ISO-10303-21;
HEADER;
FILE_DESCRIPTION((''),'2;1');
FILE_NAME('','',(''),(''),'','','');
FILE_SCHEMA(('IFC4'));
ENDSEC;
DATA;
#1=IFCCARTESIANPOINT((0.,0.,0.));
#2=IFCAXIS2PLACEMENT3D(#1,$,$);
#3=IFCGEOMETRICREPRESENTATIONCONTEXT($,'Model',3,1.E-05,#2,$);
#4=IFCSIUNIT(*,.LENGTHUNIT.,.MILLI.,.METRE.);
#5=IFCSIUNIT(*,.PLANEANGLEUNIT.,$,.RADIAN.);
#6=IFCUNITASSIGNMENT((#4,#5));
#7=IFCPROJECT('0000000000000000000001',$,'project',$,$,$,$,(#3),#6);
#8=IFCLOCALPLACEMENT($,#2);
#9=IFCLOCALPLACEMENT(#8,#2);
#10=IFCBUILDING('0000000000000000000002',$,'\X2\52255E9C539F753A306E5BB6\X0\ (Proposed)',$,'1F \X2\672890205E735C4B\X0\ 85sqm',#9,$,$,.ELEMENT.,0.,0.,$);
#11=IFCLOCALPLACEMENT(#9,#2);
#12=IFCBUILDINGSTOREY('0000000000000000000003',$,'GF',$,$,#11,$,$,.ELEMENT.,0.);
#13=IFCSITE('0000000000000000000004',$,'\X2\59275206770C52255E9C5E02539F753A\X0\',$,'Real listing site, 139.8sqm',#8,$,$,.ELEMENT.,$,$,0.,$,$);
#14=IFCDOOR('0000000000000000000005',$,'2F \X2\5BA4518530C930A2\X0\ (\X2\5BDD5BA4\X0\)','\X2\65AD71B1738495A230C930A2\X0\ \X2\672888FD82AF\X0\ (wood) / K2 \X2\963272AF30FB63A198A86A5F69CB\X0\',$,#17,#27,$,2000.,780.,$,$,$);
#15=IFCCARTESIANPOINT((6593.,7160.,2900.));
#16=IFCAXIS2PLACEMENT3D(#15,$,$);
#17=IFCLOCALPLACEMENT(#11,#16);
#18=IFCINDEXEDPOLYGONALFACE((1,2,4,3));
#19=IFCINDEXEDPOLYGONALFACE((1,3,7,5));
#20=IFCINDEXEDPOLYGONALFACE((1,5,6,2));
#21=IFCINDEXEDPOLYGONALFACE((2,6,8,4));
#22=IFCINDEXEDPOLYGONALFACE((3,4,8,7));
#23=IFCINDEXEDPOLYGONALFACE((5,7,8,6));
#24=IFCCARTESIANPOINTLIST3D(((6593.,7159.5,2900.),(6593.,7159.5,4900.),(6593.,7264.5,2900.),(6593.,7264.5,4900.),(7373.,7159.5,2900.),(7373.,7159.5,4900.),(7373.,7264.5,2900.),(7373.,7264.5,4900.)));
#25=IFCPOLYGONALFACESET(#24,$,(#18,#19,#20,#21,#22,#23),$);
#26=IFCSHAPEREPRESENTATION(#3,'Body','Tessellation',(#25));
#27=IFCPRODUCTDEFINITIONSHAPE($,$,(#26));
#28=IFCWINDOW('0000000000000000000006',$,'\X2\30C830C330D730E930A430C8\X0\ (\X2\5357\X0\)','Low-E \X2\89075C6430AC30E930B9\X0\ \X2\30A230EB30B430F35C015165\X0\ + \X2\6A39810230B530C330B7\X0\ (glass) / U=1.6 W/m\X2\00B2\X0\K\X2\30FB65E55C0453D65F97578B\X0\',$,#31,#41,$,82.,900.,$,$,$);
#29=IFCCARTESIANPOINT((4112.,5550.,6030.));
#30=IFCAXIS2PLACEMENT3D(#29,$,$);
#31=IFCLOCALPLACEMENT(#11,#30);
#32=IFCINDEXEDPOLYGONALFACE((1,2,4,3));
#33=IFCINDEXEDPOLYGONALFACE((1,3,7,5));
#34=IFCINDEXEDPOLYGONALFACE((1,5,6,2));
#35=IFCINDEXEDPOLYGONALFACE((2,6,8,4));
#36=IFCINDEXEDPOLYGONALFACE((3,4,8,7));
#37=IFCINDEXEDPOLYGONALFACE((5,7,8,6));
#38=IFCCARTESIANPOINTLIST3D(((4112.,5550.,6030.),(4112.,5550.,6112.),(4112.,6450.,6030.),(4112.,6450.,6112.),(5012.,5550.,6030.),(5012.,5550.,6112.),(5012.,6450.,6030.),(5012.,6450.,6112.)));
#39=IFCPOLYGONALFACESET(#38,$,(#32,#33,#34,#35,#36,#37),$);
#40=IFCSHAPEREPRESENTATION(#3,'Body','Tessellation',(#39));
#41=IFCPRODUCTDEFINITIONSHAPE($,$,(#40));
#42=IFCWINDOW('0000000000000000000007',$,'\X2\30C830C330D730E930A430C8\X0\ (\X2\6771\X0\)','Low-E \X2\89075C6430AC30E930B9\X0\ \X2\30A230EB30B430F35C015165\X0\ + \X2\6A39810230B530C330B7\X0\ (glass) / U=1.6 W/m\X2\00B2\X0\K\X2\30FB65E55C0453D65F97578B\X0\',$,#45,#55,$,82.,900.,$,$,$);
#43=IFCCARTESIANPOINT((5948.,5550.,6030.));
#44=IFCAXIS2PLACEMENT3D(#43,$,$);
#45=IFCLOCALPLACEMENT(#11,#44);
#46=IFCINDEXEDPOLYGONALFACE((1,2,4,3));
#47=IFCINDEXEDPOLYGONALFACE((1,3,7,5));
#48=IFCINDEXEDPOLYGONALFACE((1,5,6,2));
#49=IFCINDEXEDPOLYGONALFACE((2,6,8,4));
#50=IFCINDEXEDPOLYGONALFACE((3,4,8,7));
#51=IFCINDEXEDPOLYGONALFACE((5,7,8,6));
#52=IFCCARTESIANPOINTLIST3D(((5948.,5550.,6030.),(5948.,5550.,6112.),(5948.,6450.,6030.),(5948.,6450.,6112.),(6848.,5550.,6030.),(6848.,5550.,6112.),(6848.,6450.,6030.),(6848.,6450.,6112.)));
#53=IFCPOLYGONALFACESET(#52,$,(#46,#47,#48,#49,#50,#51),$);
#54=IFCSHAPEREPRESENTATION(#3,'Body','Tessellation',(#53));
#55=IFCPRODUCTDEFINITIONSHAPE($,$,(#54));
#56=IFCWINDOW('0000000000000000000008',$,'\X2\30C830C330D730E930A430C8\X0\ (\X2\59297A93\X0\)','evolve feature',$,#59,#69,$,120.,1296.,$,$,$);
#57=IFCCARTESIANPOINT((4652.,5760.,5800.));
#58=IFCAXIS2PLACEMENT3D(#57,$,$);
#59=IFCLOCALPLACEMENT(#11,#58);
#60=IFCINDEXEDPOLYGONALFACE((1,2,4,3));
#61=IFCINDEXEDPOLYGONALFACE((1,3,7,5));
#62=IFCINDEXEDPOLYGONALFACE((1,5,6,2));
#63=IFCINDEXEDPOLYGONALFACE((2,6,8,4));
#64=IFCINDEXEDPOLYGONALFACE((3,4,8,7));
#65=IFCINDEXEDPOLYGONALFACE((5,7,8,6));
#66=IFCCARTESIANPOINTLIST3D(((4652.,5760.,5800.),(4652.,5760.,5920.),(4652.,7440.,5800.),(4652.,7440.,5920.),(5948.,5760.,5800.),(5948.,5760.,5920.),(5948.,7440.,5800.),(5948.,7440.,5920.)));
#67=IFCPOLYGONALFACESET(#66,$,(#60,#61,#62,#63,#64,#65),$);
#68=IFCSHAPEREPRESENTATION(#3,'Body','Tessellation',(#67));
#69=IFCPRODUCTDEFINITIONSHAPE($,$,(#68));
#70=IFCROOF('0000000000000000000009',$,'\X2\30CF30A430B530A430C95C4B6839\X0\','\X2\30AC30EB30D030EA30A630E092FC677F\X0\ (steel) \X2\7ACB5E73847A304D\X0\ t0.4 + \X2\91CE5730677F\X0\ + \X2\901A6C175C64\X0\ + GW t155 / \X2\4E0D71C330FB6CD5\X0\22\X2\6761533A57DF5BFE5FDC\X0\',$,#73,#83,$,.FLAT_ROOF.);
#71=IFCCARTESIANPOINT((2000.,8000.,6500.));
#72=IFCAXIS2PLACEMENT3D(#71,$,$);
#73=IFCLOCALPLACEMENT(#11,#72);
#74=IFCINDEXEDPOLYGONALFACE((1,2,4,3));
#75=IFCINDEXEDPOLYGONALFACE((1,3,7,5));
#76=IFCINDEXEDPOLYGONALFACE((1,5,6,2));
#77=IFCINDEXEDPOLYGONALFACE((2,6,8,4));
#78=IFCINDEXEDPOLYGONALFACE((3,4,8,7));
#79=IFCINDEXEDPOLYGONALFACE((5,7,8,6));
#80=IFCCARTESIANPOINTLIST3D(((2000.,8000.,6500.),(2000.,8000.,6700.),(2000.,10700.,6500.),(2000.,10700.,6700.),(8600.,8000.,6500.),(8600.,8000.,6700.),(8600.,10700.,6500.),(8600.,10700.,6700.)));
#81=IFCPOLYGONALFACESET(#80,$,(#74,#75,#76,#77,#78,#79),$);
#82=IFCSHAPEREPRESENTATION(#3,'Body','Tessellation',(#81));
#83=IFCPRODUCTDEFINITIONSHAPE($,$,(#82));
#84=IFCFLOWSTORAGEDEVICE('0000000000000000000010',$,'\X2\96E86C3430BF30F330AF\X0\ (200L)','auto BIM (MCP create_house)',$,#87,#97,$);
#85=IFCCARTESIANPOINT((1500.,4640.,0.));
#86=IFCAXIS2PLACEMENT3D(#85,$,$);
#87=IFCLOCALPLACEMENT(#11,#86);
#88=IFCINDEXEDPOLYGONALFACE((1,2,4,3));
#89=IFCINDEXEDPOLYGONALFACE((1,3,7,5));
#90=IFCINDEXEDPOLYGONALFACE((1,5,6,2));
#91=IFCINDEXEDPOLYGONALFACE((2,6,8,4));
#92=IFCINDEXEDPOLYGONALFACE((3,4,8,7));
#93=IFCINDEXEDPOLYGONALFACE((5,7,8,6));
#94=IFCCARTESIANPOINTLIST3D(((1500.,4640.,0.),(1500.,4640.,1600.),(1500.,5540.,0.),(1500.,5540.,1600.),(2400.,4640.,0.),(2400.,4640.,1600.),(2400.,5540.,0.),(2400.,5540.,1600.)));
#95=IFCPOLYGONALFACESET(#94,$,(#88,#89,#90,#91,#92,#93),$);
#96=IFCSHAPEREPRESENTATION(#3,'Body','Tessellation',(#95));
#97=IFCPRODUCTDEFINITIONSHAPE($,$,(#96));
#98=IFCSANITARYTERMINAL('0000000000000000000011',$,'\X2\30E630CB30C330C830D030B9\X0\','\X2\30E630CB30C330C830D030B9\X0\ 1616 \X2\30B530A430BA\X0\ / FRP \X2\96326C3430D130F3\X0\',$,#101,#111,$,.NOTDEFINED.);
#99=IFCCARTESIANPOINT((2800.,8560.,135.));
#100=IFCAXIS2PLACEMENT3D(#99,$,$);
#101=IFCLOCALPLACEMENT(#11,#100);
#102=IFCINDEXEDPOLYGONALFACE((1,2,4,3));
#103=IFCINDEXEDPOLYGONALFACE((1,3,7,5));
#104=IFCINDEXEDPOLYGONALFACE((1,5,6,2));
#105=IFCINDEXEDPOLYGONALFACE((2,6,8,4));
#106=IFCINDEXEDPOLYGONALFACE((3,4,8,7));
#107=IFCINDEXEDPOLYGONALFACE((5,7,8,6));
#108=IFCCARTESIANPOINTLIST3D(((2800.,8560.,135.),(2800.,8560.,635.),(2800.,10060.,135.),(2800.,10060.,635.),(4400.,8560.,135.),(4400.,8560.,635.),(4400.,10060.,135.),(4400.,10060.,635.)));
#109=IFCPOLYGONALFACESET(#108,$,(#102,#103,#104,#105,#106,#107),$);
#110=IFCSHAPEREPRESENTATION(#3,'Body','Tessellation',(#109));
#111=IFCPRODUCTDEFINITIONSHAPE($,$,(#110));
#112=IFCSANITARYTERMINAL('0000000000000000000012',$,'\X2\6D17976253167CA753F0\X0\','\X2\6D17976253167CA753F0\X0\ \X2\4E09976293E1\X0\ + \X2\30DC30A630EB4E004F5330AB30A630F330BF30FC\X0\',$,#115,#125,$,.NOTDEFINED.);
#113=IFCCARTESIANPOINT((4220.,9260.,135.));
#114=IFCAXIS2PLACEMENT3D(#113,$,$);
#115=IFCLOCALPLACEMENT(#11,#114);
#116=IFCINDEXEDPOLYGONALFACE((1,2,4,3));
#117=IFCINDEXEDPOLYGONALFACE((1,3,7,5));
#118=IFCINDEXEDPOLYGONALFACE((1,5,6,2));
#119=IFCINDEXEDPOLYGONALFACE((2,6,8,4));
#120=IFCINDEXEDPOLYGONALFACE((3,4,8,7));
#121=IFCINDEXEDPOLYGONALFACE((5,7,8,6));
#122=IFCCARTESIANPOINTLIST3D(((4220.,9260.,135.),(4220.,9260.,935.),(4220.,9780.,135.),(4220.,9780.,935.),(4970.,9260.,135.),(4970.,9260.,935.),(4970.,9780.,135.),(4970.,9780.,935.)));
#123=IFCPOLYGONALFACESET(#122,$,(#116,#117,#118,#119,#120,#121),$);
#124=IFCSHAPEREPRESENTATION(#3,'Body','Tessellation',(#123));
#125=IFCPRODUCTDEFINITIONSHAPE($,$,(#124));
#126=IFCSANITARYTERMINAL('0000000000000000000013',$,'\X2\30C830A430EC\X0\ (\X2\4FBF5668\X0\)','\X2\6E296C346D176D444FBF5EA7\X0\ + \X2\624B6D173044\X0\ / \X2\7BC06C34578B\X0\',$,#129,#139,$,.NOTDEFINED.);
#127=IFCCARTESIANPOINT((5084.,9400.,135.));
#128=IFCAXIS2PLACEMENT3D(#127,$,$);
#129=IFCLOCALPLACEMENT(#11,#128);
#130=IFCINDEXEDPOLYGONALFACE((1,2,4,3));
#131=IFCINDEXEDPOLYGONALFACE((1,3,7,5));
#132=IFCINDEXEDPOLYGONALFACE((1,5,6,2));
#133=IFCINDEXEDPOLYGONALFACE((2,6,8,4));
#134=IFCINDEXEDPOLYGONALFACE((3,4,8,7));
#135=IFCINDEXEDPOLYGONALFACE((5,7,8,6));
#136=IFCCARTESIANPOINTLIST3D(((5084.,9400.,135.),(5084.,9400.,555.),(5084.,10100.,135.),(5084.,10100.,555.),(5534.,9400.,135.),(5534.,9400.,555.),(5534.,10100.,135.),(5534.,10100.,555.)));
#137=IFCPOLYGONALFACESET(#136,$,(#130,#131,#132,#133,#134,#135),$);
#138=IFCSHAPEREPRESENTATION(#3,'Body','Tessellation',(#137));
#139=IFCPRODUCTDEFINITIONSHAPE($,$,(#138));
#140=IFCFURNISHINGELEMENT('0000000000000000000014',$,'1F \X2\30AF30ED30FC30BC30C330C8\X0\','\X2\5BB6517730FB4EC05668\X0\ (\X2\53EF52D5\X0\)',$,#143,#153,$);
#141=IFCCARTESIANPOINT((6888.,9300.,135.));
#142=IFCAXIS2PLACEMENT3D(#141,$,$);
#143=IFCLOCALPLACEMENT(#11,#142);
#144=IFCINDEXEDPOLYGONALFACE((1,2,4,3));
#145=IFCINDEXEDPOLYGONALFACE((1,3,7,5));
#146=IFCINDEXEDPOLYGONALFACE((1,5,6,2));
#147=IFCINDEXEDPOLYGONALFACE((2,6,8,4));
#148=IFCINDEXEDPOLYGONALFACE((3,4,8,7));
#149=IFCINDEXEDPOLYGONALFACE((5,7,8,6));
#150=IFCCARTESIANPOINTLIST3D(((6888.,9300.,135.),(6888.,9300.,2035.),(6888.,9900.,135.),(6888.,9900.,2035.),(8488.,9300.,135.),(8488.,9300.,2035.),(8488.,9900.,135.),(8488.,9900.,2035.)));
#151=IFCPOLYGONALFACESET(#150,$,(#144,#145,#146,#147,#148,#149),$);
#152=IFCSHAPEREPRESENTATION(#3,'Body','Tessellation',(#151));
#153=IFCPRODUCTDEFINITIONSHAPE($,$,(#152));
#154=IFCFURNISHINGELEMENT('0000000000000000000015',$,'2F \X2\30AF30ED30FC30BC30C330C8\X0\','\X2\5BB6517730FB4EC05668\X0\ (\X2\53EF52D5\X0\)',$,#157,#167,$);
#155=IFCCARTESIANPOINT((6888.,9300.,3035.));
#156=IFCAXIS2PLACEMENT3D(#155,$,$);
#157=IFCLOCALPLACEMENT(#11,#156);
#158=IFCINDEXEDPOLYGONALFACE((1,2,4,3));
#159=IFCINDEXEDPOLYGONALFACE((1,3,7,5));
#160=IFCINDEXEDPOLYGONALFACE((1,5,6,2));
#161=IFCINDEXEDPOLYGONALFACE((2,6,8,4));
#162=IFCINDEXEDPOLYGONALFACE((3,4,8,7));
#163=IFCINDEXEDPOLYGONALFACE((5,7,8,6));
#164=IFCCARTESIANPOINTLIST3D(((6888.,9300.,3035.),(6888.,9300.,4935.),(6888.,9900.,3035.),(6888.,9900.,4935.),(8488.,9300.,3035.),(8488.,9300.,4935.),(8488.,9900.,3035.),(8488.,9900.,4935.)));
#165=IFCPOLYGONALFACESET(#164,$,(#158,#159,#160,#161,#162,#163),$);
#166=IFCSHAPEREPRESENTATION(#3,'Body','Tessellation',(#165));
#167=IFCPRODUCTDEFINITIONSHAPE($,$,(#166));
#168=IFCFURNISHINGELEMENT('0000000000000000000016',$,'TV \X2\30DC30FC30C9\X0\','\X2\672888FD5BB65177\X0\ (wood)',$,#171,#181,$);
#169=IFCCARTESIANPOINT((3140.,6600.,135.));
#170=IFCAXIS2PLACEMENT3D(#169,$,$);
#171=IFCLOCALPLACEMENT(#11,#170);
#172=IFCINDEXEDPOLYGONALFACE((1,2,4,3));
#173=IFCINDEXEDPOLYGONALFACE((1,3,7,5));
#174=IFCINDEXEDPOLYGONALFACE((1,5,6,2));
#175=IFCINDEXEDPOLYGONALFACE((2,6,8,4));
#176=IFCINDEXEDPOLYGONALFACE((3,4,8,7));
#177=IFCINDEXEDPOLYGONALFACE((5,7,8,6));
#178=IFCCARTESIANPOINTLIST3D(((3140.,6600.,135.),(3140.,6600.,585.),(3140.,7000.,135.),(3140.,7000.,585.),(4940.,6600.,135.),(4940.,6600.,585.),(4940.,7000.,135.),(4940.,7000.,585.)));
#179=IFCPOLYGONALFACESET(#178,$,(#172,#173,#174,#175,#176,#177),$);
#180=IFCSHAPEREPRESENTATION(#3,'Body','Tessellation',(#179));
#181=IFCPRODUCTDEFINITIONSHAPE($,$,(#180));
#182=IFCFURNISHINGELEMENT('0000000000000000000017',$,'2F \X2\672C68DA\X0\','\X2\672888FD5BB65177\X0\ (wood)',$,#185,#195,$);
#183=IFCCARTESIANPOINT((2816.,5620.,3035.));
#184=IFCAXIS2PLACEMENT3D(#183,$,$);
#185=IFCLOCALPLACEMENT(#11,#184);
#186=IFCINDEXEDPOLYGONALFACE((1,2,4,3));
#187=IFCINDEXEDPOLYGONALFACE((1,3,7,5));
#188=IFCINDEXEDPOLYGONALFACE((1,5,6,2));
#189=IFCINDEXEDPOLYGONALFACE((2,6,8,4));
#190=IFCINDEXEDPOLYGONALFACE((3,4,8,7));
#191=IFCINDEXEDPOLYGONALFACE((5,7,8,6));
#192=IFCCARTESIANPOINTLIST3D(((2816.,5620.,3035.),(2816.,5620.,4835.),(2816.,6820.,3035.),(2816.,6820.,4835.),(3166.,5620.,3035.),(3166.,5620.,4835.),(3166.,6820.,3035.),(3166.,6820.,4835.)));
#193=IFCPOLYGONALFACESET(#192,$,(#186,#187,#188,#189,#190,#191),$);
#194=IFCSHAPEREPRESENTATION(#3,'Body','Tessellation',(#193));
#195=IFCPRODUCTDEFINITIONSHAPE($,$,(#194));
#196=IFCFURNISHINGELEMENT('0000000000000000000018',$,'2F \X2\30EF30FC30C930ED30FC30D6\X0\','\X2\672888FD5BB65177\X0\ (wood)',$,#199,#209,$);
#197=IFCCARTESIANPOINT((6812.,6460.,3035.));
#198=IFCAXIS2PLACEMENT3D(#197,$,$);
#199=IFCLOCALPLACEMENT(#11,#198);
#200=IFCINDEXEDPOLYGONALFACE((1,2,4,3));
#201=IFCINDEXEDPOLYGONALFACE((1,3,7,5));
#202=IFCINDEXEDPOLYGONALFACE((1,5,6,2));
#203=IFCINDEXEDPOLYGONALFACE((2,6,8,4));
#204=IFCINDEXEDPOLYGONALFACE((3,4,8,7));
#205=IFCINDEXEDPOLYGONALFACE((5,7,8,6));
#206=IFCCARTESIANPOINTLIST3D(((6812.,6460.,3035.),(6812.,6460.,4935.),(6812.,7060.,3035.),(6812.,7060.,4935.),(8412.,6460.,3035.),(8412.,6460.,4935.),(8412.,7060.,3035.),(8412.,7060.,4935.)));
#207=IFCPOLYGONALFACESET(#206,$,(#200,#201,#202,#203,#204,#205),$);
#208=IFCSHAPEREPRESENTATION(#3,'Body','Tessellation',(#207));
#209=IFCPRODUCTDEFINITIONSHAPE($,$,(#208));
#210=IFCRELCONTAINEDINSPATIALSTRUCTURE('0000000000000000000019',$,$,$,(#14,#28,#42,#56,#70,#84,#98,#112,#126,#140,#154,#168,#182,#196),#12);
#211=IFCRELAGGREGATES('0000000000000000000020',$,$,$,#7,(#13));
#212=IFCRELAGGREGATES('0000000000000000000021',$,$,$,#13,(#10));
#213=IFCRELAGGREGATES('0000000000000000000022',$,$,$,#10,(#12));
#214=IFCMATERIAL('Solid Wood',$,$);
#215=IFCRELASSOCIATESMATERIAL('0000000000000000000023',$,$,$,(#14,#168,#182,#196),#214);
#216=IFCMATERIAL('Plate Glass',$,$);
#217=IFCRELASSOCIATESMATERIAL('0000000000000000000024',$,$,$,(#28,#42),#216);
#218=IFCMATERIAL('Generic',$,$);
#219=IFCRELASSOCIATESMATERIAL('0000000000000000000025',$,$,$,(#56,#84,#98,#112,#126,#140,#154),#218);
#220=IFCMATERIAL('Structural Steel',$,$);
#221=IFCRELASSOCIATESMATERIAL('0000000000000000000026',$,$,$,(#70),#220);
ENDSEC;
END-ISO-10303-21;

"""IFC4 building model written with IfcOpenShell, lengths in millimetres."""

from ifc_helpers import new_model, si_unit, frame, frame_2d, origin, place, context, project, spatial, rectangle, extrude, material, element, save


model = new_model("IFC4")

# Units and contexts
model_context = context("Model", 3, precision=1e-05, world=origin())
ifc_project = project(units=[si_unit("LENGTHUNIT", "METRE", prefix="MILLI"), si_unit("PLANEANGLEUNIT", "RADIAN")], contexts=[model_context])

# Site, building, storey
site_placement = place(None, origin())
site = spatial("IfcSite", under=ifc_project, at=site_placement, Name="大分県別府市原町", ObjectType="Real listing site, 139.8sqm", CompositionType="ELEMENT", RefElevation=0.0)
building_placement = place(site_placement, origin())
building = spatial("IfcBuilding", under=site, at=building_placement, Name="別府原町の家 (Proposed)", ObjectType="1F 木造平屋 85sqm", CompositionType="ELEMENT", ElevationOfRefHeight=0.0, ElevationOfTerrain=0.0)
storey_placement = place(building_placement, origin())
storey = spatial("IfcBuildingStorey", under=building, at=storey_placement, Name="GF", CompositionType="ELEMENT", Elevation=0.0)

# Shared definitions
ifc_material_1 = material(Name="Solid Wood")
ifc_material_2 = material(Name="Plate Glass")

# Door
door_1_placement = place(storey_placement, frame((6593.0, 7160.0, 2900.0)))
element("IfcDoor", 1, at=door_1_placement, inside=storey, material=ifc_material_1, Name="2F 室内ドア (寝室)", Description="断熱玄関ドア 木製芯 (wood) / K2 防犯・採風機構", OverallHeight=2000.0, OverallWidth=780.0, context=model_context, shape_type="SweptSolid", body=[
    extrude(rectangle(XDim=780.0, YDim=105.0, at=frame_2d((390.0, 52.0))), frame((6593.0, 7160.0, 2900.0)), (0.0, 0.0, 1.0), 2000.0),
])

# Windows
window_1_placement = place(storey_placement, frame((4112.0, 5550.0, 6030.0)))
element("IfcWindow", 2, at=window_1_placement, inside=storey, material=ifc_material_2, Name="トップライト (南)", Description="Low-E 複層ガラス アルゴン封入 + 樹脂サッシ (glass) / U=1.6 W/m²K・日射取得型", OverallHeight=82.0, OverallWidth=900.0, context=model_context, shape_type="SweptSolid", body=[
    extrude(rectangle(XDim=900.0, YDim=900.0, at=frame_2d((450.0, 450.0))), frame((4112.0, 5550.0, 6030.0)), (0.0, 0.0, 1.0), 82.0),
])
window_2_placement = place(storey_placement, frame((5948.0, 5550.0, 6030.0)))
element("IfcWindow", 3, at=window_2_placement, inside=storey, material=ifc_material_2, Name="トップライト (東)", Description="Low-E 複層ガラス アルゴン封入 + 樹脂サッシ (glass) / U=1.6 W/m²K・日射取得型", OverallHeight=82.0, OverallWidth=900.0, context=model_context, shape_type="SweptSolid", body=[
    extrude(rectangle(XDim=900.0, YDim=900.0, at=frame_2d((450.0, 450.0))), frame((5948.0, 5550.0, 6030.0)), (0.0, 0.0, 1.0), 82.0),
])
ifc_material_3 = material(Name="Generic")
window_3_placement = place(storey_placement, frame((4652.0, 5760.0, 5800.0)))
element("IfcWindow", 4, at=window_3_placement, inside=storey, material=ifc_material_3, Name="トップライト (天窓)", Description="evolve feature", OverallHeight=120.0, OverallWidth=1296.0, context=model_context, shape_type="SweptSolid", body=[
    extrude(rectangle(XDim=1296.0, YDim=1680.0, at=frame_2d((648.0, 840.0))), frame((4652.0, 5760.0, 5800.0)), (0.0, 0.0, 1.0), 120.0),
])

# Roof
ifc_material_4 = material(Name="Structural Steel")
roof_placement = place(storey_placement, frame((2000.0, 8000.0, 6500.0)))
element("IfcRoof", 5, at=roof_placement, inside=storey, material=ifc_material_4, Name="ハイサイド屋根", Description="ガルバリウム鋼板 (steel) 立平葺き t0.4 + 野地板 + 通気層 + GW t155 / 不燃・法22条区域対応", PredefinedType="FLAT_ROOF", context=model_context, shape_type="SweptSolid", body=[
    extrude(rectangle(XDim=6600.0, YDim=2700.0, at=frame_2d((3300.0, 1350.0))), frame((2000.0, 8000.0, 6500.0)), (0.0, 0.0, 1.0), 200.0),
])

# Flow storage device
flow_storage_device_placement = place(storey_placement, frame((1500.0, 4640.0, 0.0)))
element("IfcFlowStorageDevice", 6, at=flow_storage_device_placement, inside=storey, material=ifc_material_3, Name="雨水タンク (200L)", Description="auto BIM (MCP create_house)", context=model_context, shape_type="SweptSolid", body=[
    extrude(rectangle(XDim=900.0, YDim=900.0, at=frame_2d((450.0, 450.0))), frame((1500.0, 4640.0, 0.0)), (0.0, 0.0, 1.0), 1600.0),
])

# Sanitary terminals
sanitary_terminal_1_placement = place(storey_placement, frame((2800.0, 8560.0, 135.0)))
element("IfcSanitaryTerminal", 7, at=sanitary_terminal_1_placement, inside=storey, material=ifc_material_3, Name="ユニットバス", Description="ユニットバス 1616 サイズ / FRP 防水パン", PredefinedType="NOTDEFINED", context=model_context, shape_type="SweptSolid", body=[
    extrude(rectangle(XDim=1600.0, YDim=1500.0, at=frame_2d((800.0, 750.0))), frame((2800.0, 8560.0, 135.0)), (0.0, 0.0, 1.0), 500.0),
])
sanitary_terminal_2_placement = place(storey_placement, frame((4220.0, 9260.0, 135.0)))
element("IfcSanitaryTerminal", 8, at=sanitary_terminal_2_placement, inside=storey, material=ifc_material_3, Name="洗面化粧台", Description="洗面化粧台 三面鏡 + ボウル一体カウンター", PredefinedType="NOTDEFINED", context=model_context, shape_type="SweptSolid", body=[
    extrude(rectangle(XDim=750.0, YDim=520.0, at=frame_2d((375.0, 260.0))), frame((4220.0, 9260.0, 135.0)), (0.0, 0.0, 1.0), 800.0),
])
sanitary_terminal_3_placement = place(storey_placement, frame((5084.0, 9400.0, 135.0)))
element("IfcSanitaryTerminal", 9, at=sanitary_terminal_3_placement, inside=storey, material=ifc_material_3, Name="トイレ (便器)", Description="温水洗浄便座 + 手洗い / 節水型", PredefinedType="NOTDEFINED", context=model_context, shape_type="SweptSolid", body=[
    extrude(rectangle(XDim=450.0, YDim=700.0, at=frame_2d((225.0, 350.0))), frame((5084.0, 9400.0, 135.0)), (0.0, 0.0, 1.0), 420.0),
])

# Furnishing elements
furnishing_1_placement = place(storey_placement, frame((6888.0, 9300.0, 135.0)))
element("IfcFurnishingElement", 10, at=furnishing_1_placement, inside=storey, material=ifc_material_3, Name="1F クローゼット", Description="家具・什器 (可動)", context=model_context, shape_type="SweptSolid", body=[
    extrude(rectangle(XDim=1600.0, YDim=600.0, at=frame_2d((800.0, 300.0))), frame((6888.0, 9300.0, 135.0)), (0.0, 0.0, 1.0), 1900.0),
])
furnishing_2_placement = place(storey_placement, frame((6888.0, 9300.0, 3035.0)))
element("IfcFurnishingElement", 11, at=furnishing_2_placement, inside=storey, material=ifc_material_3, Name="2F クローゼット", Description="家具・什器 (可動)", context=model_context, shape_type="SweptSolid", body=[
    extrude(rectangle(XDim=1600.0, YDim=600.0, at=frame_2d((800.0, 300.0))), frame((6888.0, 9300.0, 3035.0)), (0.0, 0.0, 1.0), 1900.0),
])
furnishing_3_placement = place(storey_placement, frame((3140.0, 6600.0, 135.0)))
element("IfcFurnishingElement", 12, at=furnishing_3_placement, inside=storey, material=ifc_material_1, Name="TV ボード", Description="木製家具 (wood)", context=model_context, shape_type="SweptSolid", body=[
    extrude(rectangle(XDim=1800.0, YDim=400.0, at=frame_2d((900.0, 200.0))), frame((3140.0, 6600.0, 135.0)), (0.0, 0.0, 1.0), 450.0),
])
furnishing_4_placement = place(storey_placement, frame((2816.0, 5620.0, 3035.0)))
element("IfcFurnishingElement", 13, at=furnishing_4_placement, inside=storey, material=ifc_material_1, Name="2F 本棚", Description="木製家具 (wood)", context=model_context, shape_type="SweptSolid", body=[
    extrude(rectangle(XDim=350.0, YDim=1200.0, at=frame_2d((175.0, 600.0))), frame((2816.0, 5620.0, 3035.0)), (0.0, 0.0, 1.0), 1800.0),
])
furnishing_5_placement = place(storey_placement, frame((6812.0, 6460.0, 3035.0)))
element("IfcFurnishingElement", 14, at=furnishing_5_placement, inside=storey, material=ifc_material_1, Name="2F ワードローブ", Description="木製家具 (wood)", context=model_context, shape_type="SweptSolid", body=[
    extrude(rectangle(XDim=1600.0, YDim=600.0, at=frame_2d((800.0, 300.0))), frame((6812.0, 6460.0, 3035.0)), (0.0, 0.0, 1.0), 1900.0),
])

save(model, "model.ifc")
